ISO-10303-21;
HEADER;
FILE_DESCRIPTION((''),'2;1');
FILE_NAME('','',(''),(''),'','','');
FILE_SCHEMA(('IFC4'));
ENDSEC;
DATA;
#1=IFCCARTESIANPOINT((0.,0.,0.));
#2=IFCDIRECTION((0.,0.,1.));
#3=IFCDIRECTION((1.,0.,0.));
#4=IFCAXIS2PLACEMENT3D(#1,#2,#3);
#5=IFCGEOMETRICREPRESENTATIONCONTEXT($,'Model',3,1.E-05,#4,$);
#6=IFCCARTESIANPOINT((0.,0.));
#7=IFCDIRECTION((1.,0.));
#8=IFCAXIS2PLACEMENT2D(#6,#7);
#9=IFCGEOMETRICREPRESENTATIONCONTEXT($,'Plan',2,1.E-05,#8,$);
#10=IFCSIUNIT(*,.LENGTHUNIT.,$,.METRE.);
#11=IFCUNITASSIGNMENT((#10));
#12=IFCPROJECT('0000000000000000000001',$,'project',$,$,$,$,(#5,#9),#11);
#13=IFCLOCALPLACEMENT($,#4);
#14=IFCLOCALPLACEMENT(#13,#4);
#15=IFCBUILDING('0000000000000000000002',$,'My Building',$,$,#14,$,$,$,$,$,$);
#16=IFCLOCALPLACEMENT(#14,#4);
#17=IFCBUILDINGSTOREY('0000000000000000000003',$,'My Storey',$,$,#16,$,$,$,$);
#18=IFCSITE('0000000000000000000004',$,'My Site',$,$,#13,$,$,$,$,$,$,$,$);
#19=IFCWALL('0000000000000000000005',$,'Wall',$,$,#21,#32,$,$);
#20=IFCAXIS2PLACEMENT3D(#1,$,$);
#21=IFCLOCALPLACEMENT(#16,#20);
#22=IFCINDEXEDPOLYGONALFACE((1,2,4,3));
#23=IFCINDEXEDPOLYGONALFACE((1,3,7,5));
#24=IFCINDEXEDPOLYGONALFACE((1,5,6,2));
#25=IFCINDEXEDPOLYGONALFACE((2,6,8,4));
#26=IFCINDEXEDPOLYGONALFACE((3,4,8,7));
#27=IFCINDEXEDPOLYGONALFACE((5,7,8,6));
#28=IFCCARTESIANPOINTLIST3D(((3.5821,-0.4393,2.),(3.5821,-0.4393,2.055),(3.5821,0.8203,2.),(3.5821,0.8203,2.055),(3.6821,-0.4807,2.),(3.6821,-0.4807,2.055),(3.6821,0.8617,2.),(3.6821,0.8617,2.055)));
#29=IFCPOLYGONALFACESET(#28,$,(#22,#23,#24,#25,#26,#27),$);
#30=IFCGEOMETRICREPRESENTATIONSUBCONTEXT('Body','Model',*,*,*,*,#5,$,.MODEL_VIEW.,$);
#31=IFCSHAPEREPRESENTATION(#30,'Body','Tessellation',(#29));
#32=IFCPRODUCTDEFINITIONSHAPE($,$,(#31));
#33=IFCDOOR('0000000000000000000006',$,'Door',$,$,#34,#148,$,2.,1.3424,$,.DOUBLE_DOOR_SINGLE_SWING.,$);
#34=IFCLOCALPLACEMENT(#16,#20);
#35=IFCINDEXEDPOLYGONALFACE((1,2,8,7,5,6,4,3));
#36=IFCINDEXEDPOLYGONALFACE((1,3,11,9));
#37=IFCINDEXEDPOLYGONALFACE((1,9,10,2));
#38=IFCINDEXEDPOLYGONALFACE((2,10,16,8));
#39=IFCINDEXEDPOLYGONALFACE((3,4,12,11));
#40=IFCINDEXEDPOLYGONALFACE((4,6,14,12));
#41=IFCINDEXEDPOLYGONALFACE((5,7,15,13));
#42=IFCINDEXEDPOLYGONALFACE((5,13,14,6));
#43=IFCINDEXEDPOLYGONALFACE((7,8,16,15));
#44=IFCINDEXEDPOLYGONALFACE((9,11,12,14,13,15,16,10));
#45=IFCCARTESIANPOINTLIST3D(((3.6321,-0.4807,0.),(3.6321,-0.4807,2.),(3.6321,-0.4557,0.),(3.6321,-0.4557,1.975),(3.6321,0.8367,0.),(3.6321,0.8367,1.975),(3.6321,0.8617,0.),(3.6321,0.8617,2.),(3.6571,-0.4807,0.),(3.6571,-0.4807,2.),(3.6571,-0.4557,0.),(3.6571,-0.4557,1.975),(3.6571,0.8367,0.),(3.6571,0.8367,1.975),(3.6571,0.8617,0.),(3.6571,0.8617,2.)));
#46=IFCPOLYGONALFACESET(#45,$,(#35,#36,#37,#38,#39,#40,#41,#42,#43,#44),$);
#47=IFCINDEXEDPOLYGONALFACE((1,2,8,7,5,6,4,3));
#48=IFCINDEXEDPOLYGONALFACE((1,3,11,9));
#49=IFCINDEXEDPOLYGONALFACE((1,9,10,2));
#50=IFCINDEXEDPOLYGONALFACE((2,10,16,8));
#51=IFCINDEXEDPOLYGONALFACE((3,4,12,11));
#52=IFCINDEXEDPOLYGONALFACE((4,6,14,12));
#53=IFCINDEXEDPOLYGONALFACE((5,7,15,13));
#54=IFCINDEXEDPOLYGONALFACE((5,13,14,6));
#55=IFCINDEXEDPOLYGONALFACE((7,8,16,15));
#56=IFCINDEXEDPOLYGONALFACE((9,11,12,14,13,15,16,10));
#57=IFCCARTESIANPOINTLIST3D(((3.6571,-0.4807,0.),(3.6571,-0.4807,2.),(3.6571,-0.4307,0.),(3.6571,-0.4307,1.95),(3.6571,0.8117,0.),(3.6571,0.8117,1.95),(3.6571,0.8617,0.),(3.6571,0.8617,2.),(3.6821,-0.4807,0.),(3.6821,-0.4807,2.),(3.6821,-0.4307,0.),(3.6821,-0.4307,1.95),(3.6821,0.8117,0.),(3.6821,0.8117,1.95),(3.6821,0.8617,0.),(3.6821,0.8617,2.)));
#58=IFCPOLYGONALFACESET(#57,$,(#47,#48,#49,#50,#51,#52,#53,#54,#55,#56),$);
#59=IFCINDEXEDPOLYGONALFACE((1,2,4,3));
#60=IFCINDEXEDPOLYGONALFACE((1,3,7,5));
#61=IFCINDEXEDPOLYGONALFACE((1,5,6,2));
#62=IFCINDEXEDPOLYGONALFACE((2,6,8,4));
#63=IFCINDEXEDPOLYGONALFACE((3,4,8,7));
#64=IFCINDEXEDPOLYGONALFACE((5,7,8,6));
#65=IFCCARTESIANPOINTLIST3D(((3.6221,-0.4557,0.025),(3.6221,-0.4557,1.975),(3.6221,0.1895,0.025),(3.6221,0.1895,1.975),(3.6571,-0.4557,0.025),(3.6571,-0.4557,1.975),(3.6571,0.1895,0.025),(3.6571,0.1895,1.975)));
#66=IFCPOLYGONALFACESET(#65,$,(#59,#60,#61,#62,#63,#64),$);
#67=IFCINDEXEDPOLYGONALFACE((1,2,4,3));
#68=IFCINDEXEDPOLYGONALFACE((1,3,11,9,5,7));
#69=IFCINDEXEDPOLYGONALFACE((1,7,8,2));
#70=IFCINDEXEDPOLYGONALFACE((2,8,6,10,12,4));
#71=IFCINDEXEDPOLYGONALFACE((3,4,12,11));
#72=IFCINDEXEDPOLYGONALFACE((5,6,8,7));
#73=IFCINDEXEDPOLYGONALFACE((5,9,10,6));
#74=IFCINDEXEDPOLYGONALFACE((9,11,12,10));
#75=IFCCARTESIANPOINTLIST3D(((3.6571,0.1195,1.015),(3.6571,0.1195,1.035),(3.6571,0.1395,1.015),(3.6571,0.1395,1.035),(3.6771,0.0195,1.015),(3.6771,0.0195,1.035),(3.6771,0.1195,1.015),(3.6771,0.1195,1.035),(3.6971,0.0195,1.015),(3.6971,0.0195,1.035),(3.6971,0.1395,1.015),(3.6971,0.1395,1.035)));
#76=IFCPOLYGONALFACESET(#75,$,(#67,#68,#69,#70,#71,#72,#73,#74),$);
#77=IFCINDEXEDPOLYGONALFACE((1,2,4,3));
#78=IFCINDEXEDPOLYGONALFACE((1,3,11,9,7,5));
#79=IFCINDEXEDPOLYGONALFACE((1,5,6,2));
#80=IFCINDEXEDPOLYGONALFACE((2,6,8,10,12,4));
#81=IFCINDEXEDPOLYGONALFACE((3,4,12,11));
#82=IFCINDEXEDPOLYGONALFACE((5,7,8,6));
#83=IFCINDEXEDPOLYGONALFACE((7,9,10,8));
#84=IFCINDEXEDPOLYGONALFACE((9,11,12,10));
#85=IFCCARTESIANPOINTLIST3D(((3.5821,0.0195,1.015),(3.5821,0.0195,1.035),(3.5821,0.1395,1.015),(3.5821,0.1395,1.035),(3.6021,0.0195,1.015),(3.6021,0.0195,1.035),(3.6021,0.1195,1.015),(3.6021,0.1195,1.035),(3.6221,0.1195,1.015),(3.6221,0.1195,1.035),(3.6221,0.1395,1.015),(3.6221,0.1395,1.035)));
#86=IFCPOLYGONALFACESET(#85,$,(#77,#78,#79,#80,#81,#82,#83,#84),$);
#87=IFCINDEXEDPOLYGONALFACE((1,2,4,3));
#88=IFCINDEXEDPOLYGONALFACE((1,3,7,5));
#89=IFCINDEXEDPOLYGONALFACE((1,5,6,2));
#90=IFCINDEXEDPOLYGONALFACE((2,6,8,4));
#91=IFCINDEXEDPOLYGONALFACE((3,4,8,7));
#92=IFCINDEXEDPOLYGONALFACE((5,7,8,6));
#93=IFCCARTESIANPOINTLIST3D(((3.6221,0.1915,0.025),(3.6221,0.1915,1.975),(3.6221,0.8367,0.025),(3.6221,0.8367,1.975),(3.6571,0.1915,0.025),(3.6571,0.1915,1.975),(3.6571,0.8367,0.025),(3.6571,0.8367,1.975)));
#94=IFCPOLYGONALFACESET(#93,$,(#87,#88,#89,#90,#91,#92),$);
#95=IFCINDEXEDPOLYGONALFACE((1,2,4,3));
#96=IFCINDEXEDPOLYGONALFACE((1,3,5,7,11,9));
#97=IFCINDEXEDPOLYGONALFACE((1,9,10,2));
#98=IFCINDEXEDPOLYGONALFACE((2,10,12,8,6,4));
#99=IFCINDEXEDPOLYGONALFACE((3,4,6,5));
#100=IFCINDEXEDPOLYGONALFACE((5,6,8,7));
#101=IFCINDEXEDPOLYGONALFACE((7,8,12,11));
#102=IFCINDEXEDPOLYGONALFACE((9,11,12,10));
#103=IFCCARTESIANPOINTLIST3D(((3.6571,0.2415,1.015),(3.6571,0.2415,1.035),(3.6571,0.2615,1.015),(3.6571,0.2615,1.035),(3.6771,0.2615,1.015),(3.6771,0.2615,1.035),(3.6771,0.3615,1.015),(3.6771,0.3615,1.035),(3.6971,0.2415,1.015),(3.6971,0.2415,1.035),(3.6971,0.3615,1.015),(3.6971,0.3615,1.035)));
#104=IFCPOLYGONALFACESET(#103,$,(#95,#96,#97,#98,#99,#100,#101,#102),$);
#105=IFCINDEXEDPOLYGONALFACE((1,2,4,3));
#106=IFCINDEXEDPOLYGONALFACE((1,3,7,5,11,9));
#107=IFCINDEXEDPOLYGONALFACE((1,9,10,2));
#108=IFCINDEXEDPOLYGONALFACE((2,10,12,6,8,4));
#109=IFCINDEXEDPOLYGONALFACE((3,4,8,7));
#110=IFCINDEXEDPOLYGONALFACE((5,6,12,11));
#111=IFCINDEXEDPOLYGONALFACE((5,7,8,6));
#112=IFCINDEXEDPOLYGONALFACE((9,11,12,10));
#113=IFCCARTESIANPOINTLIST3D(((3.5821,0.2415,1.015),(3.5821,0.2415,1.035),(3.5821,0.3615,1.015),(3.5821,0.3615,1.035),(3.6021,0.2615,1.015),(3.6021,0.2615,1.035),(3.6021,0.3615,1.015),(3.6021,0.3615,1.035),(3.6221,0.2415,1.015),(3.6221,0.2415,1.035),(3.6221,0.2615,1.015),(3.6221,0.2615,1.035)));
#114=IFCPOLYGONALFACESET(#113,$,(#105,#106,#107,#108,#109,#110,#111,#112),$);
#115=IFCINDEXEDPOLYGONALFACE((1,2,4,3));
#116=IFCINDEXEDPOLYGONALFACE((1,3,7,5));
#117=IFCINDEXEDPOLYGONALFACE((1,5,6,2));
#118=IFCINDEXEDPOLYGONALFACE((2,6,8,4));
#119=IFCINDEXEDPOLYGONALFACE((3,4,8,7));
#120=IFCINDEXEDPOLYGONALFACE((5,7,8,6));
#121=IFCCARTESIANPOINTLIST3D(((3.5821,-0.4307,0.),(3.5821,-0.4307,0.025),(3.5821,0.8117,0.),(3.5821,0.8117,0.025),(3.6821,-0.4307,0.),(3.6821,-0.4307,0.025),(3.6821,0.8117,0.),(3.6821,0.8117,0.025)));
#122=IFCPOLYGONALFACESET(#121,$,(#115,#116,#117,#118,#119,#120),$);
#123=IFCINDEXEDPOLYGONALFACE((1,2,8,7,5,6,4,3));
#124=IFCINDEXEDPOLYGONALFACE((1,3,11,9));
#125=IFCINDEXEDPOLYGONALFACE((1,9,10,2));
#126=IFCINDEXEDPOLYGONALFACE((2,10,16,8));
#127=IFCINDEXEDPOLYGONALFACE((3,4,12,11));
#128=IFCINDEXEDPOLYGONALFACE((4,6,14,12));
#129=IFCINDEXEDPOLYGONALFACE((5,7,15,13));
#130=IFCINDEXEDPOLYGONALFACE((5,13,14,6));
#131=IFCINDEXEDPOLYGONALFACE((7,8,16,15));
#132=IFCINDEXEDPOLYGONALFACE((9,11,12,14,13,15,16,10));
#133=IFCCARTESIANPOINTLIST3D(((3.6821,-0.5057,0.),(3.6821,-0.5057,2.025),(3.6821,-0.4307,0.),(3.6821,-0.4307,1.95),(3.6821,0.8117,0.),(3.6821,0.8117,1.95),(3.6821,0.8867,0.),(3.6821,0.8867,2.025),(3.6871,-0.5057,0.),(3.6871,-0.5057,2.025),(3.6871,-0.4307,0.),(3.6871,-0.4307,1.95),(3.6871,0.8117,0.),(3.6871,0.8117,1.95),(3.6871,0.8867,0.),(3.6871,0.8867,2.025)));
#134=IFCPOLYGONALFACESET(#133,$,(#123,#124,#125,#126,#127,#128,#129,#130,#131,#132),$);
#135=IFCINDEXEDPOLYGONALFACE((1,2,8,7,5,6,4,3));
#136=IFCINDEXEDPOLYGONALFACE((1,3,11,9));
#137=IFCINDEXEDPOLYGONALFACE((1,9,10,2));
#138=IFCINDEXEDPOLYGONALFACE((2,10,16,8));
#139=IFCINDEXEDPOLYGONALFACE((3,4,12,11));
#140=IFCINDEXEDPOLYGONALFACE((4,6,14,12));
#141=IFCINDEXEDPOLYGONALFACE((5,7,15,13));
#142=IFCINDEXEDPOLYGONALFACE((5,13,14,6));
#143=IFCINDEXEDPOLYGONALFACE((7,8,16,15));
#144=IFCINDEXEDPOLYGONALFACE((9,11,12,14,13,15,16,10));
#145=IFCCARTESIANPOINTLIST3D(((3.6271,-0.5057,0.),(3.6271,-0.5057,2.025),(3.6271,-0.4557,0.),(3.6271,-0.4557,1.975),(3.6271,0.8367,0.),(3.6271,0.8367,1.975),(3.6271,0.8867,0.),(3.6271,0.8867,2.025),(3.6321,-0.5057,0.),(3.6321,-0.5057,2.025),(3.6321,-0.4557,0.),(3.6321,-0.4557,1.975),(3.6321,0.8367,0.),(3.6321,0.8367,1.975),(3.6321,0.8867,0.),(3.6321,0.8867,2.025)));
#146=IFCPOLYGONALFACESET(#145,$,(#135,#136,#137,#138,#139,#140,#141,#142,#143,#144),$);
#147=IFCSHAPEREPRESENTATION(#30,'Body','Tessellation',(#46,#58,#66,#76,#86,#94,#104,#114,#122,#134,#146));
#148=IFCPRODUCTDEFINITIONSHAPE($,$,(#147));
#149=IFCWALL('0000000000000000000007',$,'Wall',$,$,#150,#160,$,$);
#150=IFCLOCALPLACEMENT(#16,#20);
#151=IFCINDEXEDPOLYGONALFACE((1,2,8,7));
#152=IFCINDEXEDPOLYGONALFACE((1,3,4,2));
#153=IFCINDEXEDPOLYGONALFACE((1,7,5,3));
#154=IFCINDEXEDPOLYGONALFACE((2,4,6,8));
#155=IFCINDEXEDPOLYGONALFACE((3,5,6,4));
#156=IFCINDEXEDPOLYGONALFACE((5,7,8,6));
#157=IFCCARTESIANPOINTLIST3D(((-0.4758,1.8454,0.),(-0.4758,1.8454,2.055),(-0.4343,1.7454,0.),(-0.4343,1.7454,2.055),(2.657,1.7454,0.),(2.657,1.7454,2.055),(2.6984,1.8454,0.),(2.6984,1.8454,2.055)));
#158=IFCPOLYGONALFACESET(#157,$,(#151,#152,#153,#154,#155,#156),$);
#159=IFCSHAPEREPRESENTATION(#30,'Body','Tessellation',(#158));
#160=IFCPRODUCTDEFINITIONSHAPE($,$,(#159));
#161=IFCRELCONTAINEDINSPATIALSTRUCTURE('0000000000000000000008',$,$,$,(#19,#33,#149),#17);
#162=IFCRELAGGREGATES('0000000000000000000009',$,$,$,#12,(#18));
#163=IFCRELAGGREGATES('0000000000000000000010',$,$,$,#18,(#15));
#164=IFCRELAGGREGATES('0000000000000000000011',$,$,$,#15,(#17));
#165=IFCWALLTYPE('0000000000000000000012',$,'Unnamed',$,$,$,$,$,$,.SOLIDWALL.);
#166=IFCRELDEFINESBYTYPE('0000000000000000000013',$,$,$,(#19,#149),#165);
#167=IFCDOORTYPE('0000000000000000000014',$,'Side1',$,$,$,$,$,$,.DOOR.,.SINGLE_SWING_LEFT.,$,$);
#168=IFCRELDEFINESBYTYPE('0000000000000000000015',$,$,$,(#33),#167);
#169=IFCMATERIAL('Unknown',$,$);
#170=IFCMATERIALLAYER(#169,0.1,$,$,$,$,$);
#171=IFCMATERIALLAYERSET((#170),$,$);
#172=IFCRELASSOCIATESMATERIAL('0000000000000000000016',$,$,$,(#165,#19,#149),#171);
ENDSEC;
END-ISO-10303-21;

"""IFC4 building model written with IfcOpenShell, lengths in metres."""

from ifc_helpers import new_model, entity, si_unit, frame, origin_with_axes, origin_2d_with_axis, place, context, subcontext, project, spatial, line, indexed_curve, outline, extrude, shape, source, transform, mapped, material, layer, layer_set, layer_usage, type_object, type_shapes, element, fill, save


model = new_model("IFC4")

# Units and contexts
model_context = context("Model", 3, precision=1e-05, world=origin_with_axes())
plan_context = context("Plan", 2, precision=1e-05, world=origin_2d_with_axis())
body_context_1 = subcontext(model_context, "Body", "Model", "MODEL_VIEW")
body_context_2 = subcontext(plan_context, "Body", "Plan", "PLAN_VIEW")
ifc_project = project(units=[si_unit("LENGTHUNIT", "METRE")], contexts=[model_context, plan_context])

# Site, building, storey
site_placement = place(None, origin_with_axes())
site = spatial("IfcSite", under=ifc_project, at=site_placement, Name="My Site")
building_placement = place(site_placement, origin_with_axes())
building = spatial("IfcBuilding", under=site, at=building_placement, Name="My Building")
storey_placement = place(building_placement, origin_with_axes())
storey = spatial("IfcBuildingStorey", under=building, at=storey_placement, Name="My Storey")

# Shared definitions
ifc_material = material(Name="Unknown")

# Shared definitions
ifc_layer_1 = layer(ifc_material, 0.1)
ifc_layer_set_1 = layer_set([ifc_layer_1])
wall_type = type_object("IfcWallType", Name="Unnamed", PredefinedType="SOLIDWALL", material=ifc_layer_set_1)

# Wall, opening, door
ifc_layer_usage_1 = layer_usage(ifc_layer_set_1, "AXIS2", "POSITIVE", 0.0)
wall_1_placement = place(storey_placement, frame((3.6821, -0.4807, 0.0), z_axis=(0.0, 0.0, 1.0), x_axis=(0.0, 1.0, 0.0)))
wall_1 = element("IfcWall", 1, at=wall_1_placement, inside=storey, type_object=wall_type, material=ifc_layer_usage_1, Name="Wall", context=body_context_1, shape_type="SweptSolid", body=[
    extrude(outline(indexed_curve([(0.0, 0.0), (0.0414, 0.1), (1.301, 0.1), (1.3424, 0.0)], segments=[line(1, 2, 3, 4, 1)])), origin_with_axes(), (0.0, 0.0, 1.0), 2.055),
])
shared_shape_1 = source(origin_with_axes(), body_context_1, "Body", "SweptSolid", [
    extrude(outline(indexed_curve([(0.0, 0.0), (1.3424, 0.0), (1.3424, 2.0), (0.0, 2.0)], segments=[line(1, 2, 3, 4, 1)])), frame((0.0, -0.6, 0.0), z_axis=(0.0, -1.0, 0.0), x_axis=(1.0, 0.0, 0.0)), (0.0, 0.0, -1.0), 1.2),
])
opening_1_placement = place(wall_1_placement, frame((0.0, 0.0, 0.0), z_axis=(0.0, 0.0, 1.0), x_axis=(1.0, 0.0, 0.0)))
opening_1 = element("IfcOpeningElement", 2, at=opening_1_placement, cuts=wall_1, PredefinedType="OPENING", context=body_context_1, shape_type="MappedRepresentation", body=[
    mapped(shared_shape_1, transform((0.0, 0.0, 0.0), x_axis=(1.0, 0.0, 0.0), y_axis=(0.0, 1.0, 0.0), z_axis=(0.0, 0.0, 1.0), scale=1.0)),
])
door_type_1 = type_object("IfcDoorType", Name="Side1", OperationType="SINGLE_SWING_LEFT", PredefinedType="DOOR")
shared_shape_2 = source(origin_with_axes(), body_context_1, "Body", "SweptSolid", [
    extrude(outline(indexed_curve([(0.0, 0.0), (0.0, 2.0), (1.3424, 2.0), (1.3424, 0.0), (1.3174, 0.0), (1.3174, 1.975), (0.025, 1.975), (0.025, 0.0)], segments=[line(1, 2, 3, 4, 5, 6, 7, 8, 1)])), frame((0.0, 0.025, 0.0), z_axis=(0.0, -1.0, 0.0), x_axis=(1.0, 0.0, 0.0)), (0.0, 0.0, -1.0), 0.025),
    extrude(outline(indexed_curve([(0.0, 0.0), (0.0, 2.0), (1.3424, 2.0), (1.3424, 0.0), (1.2924, 0.0), (1.2924, 1.95), (0.05, 1.95), (0.05, 0.0)], segments=[line(1, 2, 3, 4, 5, 6, 7, 8, 1)])), frame((0.0, 0.0, 0.0), z_axis=(0.0, -1.0, 0.0), x_axis=(1.0, 0.0, 0.0)), (0.0, 0.0, -1.0), 0.025),
    extrude(outline(indexed_curve([(0.0, 0.0), (0.6452, 0.0), (0.6452, 0.035), (0.0, 0.035)], segments=[line(1, 2, 3, 4, 1)])), frame((0.025, 0.025, 0.025), z_axis=(0.0, 0.0, 1.0), x_axis=(1.0, 0.0, 0.0)), (0.0, 0.0, 1.0), 1.95),
    extrude(outline(indexed_curve([(0.0, 0.0), (0.0, -0.04), (-0.12, -0.04), (-0.12, -0.02), (-0.02, -0.02), (-0.02, 0.0)], segments=[line(1, 2, 3, 4, 5, 6, 1)])), frame((0.6202, 0.025, 1.015), z_axis=(0.0, 0.0, 1.0), x_axis=(1.0, 0.0, 0.0)), (0.0, 0.0, 1.0), 0.02),
    extrude(outline(indexed_curve([(0.0, 0.0), (0.0, 0.04), (-0.12, 0.04), (-0.12, 0.02), (-0.02, 0.02), (-0.02, 0.0)], segments=[line(1, 2, 3, 4, 5, 6, 1)])), frame((0.6202, 0.06, 1.015), z_axis=(0.0, 0.0, 1.0), x_axis=(1.0, 0.0, 0.0)), (0.0, 0.0, 1.0), 0.02),
    extrude(outline(indexed_curve([(0.0, 0.035), (-0.6452, 0.035), (-0.6452, 0.0), (0.0, 0.0), (0.0, 0.035)])), frame((1.3174, 0.025, 0.025), z_axis=(0.0, 0.0, 1.0), x_axis=(1.0, 0.0, 0.0)), (0.0, 0.0, 1.0), 1.95),
    extrude(outline(indexed_curve([(0.0, 0.0), (0.0, -0.04), (0.12, -0.04), (0.12, -0.02), (0.02, -0.02), (0.02, 0.0)], segments=[line(1, 2, 3, 4, 5, 6, 1)])), frame((0.7222, 0.025, 1.015), z_axis=(0.0, 0.0, 1.0), x_axis=(1.0, 0.0, 0.0)), (0.0, 0.0, 1.0), 0.02),
    extrude(outline(indexed_curve([(0.0, 0.0), (0.0, 0.04), (0.12, 0.04), (0.12, 0.02), (0.02, 0.02), (0.02, 0.0)], segments=[line(1, 2, 3, 4, 5, 6, 1)])), frame((0.7222, 0.06, 1.015), z_axis=(0.0, 0.0, 1.0), x_axis=(1.0, 0.0, 0.0)), (0.0, 0.0, 1.0), 0.02),
    extrude(outline(indexed_curve([(0.0, 0.1), (1.2424, 0.1), (1.2424, 0.0), (0.0, 0.0), (0.0, 0.1)])), frame((0.05, 0.0, 0.0), z_axis=(0.0, 0.0, 1.0), x_axis=(1.0, 0.0, 0.0)), (0.0, 0.0, 1.0), 0.025),
    extrude(outline(indexed_curve([(0.0, 0.0), (0.0, 2.025), (1.3924, 2.025), (1.3924, 0.0), (1.3174, 0.0), (1.3174, 1.95), (0.075, 1.95), (0.075, 0.0)], segments=[line(1, 2, 3, 4, 5, 6, 7, 8, 1)])), frame((-0.025, -0.005, 0.0), z_axis=(0.0, -1.0, 0.0), x_axis=(1.0, 0.0, 0.0)), (0.0, 0.0, -1.0), 0.005),
    extrude(outline(indexed_curve([(0.0, 0.0), (0.0, 2.025), (1.3924, 2.025), (1.3924, 0.0), (1.3424, 0.0), (1.3424, 1.975), (0.05, 1.975), (0.05, 0.0)], segments=[line(1, 2, 3, 4, 5, 6, 7, 8, 1)])), frame((-0.025, 0.05, 0.0), z_axis=(0.0, -1.0, 0.0), x_axis=(1.0, 0.0, 0.0)), (0.0, 0.0, -1.0), 0.005),
])
shared_shape_3 = source(origin_with_axes(), body_context_2, "Body", "Curve2D", [
    entity("IfcIndexedPolyCurve", entity("IfcCartesianPointList2D", [[0.0, 0.0], [0.0, 0.05], [0.025, 0.05], [0.025, 0.025], [0.05, 0.025], [0.05, 0.0]]), [entity("IfcLineIndex", [1, 2, 3, 4, 5, 6, 1])]),
    entity("IfcIndexedPolyCurve", entity("IfcCartesianPointList2D", [[1.3424, 0.0], [1.3424, 0.05], [1.3174, 0.05], [1.3174, 0.025], [1.2924, 0.025], [1.2924, 0.0]]), [entity("IfcLineIndex", [1, 2, 3, 4, 5, 6, 1])]),
    entity("IfcTrimmedCurve", entity("IfcEllipse", entity("IfcAxis2Placement2D", entity("IfcCartesianPoint", [0.06, 0.05]), entity("IfcDirection", [1.0, 0.0])), 0.6112, 0.6462), [entity("IfcCartesianPoint", [0.6712, 0.05])], [entity("IfcCartesianPoint", [0.06, 0.6962])], True, "CARTESIAN"),
    entity("IfcIndexedPolyCurve", entity("IfcCartesianPointList2D", [[0.025, 0.05], [0.06, 0.05], [0.06, 0.6962], [0.025, 0.6962]]), [entity("IfcLineIndex", [1, 2, 3, 4, 1])]),
    entity("IfcTrimmedCurve", entity("IfcEllipse", entity("IfcAxis2Placement2D", entity("IfcCartesianPoint", [1.2824, 0.05]), entity("IfcDirection", [1.0, 0.0])), 0.6112, 0.6462), [entity("IfcCartesianPoint", [1.2824, 0.6962])], [entity("IfcCartesianPoint", [0.6712, 0.05])], True, "CARTESIAN"),
    entity("IfcIndexedPolyCurve", entity("IfcCartesianPointList2D", [[1.3174, 0.05], [1.2824, 0.05], [1.2824, 0.6962], [1.3174, 0.6962]]), [entity("IfcLineIndex", [1, 2, 3, 4, 1])]),
])
type_shapes(door_type_1, [shared_shape_2, shared_shape_3])
door_1_placement = place(opening_1_placement, frame((0.0, 0.0, 0.0), z_axis=(0.0, 0.0, 1.0), x_axis=(1.0, 0.0, 0.0)))
door_1 = element("IfcDoor", 3, at=door_1_placement, inside=storey, type_object=door_type_1, Name="Door", OperationType="DOUBLE_DOOR_SINGLE_SWING", OverallHeight=2.0, OverallWidth=1.3424, shapes=[
    shape(body_context_1, "Body", "MappedRepresentation", [mapped(shared_shape_2, transform((0.0, 0.0, 0.0), x_axis=(1.0, 0.0, 0.0), y_axis=(0.0, 1.0, 0.0), z_axis=(0.0, 0.0, 1.0), scale=1.0))]),
    shape(body_context_2, "Body", "MappedRepresentation", [mapped(shared_shape_3, transform((0.0, 0.0, 0.0), x_axis=(1.0, 0.0, 0.0), y_axis=(0.0, 1.0, 0.0), z_axis=(0.0, 0.0, 1.0), scale=1.0))]),
])
fill(opening_1, door_1)

# Wall
ifc_layer_usage_2 = layer_usage(ifc_layer_set_1, "AXIS2", "POSITIVE", 0.0)
wall_2_placement = place(storey_placement, frame((2.6984, 1.8454, 0.0), z_axis=(0.0, 0.0, 1.0), x_axis=(-1.0, 0.0, 0.0)))
element("IfcWall", 4, at=wall_2_placement, inside=storey, type_object=wall_type, material=ifc_layer_usage_2, Name="Wall", context=body_context_1, shape_type="SweptSolid", body=[
    extrude(outline(indexed_curve([(0.0, 0.0), (0.0414, 0.1), (3.1328, 0.1), (3.1742, 0.0)], segments=[line(1, 2, 3, 4, 1)])), origin_with_axes(), (0.0, 0.0, 1.0), 2.055),
])

save(model, "model.ifc")
